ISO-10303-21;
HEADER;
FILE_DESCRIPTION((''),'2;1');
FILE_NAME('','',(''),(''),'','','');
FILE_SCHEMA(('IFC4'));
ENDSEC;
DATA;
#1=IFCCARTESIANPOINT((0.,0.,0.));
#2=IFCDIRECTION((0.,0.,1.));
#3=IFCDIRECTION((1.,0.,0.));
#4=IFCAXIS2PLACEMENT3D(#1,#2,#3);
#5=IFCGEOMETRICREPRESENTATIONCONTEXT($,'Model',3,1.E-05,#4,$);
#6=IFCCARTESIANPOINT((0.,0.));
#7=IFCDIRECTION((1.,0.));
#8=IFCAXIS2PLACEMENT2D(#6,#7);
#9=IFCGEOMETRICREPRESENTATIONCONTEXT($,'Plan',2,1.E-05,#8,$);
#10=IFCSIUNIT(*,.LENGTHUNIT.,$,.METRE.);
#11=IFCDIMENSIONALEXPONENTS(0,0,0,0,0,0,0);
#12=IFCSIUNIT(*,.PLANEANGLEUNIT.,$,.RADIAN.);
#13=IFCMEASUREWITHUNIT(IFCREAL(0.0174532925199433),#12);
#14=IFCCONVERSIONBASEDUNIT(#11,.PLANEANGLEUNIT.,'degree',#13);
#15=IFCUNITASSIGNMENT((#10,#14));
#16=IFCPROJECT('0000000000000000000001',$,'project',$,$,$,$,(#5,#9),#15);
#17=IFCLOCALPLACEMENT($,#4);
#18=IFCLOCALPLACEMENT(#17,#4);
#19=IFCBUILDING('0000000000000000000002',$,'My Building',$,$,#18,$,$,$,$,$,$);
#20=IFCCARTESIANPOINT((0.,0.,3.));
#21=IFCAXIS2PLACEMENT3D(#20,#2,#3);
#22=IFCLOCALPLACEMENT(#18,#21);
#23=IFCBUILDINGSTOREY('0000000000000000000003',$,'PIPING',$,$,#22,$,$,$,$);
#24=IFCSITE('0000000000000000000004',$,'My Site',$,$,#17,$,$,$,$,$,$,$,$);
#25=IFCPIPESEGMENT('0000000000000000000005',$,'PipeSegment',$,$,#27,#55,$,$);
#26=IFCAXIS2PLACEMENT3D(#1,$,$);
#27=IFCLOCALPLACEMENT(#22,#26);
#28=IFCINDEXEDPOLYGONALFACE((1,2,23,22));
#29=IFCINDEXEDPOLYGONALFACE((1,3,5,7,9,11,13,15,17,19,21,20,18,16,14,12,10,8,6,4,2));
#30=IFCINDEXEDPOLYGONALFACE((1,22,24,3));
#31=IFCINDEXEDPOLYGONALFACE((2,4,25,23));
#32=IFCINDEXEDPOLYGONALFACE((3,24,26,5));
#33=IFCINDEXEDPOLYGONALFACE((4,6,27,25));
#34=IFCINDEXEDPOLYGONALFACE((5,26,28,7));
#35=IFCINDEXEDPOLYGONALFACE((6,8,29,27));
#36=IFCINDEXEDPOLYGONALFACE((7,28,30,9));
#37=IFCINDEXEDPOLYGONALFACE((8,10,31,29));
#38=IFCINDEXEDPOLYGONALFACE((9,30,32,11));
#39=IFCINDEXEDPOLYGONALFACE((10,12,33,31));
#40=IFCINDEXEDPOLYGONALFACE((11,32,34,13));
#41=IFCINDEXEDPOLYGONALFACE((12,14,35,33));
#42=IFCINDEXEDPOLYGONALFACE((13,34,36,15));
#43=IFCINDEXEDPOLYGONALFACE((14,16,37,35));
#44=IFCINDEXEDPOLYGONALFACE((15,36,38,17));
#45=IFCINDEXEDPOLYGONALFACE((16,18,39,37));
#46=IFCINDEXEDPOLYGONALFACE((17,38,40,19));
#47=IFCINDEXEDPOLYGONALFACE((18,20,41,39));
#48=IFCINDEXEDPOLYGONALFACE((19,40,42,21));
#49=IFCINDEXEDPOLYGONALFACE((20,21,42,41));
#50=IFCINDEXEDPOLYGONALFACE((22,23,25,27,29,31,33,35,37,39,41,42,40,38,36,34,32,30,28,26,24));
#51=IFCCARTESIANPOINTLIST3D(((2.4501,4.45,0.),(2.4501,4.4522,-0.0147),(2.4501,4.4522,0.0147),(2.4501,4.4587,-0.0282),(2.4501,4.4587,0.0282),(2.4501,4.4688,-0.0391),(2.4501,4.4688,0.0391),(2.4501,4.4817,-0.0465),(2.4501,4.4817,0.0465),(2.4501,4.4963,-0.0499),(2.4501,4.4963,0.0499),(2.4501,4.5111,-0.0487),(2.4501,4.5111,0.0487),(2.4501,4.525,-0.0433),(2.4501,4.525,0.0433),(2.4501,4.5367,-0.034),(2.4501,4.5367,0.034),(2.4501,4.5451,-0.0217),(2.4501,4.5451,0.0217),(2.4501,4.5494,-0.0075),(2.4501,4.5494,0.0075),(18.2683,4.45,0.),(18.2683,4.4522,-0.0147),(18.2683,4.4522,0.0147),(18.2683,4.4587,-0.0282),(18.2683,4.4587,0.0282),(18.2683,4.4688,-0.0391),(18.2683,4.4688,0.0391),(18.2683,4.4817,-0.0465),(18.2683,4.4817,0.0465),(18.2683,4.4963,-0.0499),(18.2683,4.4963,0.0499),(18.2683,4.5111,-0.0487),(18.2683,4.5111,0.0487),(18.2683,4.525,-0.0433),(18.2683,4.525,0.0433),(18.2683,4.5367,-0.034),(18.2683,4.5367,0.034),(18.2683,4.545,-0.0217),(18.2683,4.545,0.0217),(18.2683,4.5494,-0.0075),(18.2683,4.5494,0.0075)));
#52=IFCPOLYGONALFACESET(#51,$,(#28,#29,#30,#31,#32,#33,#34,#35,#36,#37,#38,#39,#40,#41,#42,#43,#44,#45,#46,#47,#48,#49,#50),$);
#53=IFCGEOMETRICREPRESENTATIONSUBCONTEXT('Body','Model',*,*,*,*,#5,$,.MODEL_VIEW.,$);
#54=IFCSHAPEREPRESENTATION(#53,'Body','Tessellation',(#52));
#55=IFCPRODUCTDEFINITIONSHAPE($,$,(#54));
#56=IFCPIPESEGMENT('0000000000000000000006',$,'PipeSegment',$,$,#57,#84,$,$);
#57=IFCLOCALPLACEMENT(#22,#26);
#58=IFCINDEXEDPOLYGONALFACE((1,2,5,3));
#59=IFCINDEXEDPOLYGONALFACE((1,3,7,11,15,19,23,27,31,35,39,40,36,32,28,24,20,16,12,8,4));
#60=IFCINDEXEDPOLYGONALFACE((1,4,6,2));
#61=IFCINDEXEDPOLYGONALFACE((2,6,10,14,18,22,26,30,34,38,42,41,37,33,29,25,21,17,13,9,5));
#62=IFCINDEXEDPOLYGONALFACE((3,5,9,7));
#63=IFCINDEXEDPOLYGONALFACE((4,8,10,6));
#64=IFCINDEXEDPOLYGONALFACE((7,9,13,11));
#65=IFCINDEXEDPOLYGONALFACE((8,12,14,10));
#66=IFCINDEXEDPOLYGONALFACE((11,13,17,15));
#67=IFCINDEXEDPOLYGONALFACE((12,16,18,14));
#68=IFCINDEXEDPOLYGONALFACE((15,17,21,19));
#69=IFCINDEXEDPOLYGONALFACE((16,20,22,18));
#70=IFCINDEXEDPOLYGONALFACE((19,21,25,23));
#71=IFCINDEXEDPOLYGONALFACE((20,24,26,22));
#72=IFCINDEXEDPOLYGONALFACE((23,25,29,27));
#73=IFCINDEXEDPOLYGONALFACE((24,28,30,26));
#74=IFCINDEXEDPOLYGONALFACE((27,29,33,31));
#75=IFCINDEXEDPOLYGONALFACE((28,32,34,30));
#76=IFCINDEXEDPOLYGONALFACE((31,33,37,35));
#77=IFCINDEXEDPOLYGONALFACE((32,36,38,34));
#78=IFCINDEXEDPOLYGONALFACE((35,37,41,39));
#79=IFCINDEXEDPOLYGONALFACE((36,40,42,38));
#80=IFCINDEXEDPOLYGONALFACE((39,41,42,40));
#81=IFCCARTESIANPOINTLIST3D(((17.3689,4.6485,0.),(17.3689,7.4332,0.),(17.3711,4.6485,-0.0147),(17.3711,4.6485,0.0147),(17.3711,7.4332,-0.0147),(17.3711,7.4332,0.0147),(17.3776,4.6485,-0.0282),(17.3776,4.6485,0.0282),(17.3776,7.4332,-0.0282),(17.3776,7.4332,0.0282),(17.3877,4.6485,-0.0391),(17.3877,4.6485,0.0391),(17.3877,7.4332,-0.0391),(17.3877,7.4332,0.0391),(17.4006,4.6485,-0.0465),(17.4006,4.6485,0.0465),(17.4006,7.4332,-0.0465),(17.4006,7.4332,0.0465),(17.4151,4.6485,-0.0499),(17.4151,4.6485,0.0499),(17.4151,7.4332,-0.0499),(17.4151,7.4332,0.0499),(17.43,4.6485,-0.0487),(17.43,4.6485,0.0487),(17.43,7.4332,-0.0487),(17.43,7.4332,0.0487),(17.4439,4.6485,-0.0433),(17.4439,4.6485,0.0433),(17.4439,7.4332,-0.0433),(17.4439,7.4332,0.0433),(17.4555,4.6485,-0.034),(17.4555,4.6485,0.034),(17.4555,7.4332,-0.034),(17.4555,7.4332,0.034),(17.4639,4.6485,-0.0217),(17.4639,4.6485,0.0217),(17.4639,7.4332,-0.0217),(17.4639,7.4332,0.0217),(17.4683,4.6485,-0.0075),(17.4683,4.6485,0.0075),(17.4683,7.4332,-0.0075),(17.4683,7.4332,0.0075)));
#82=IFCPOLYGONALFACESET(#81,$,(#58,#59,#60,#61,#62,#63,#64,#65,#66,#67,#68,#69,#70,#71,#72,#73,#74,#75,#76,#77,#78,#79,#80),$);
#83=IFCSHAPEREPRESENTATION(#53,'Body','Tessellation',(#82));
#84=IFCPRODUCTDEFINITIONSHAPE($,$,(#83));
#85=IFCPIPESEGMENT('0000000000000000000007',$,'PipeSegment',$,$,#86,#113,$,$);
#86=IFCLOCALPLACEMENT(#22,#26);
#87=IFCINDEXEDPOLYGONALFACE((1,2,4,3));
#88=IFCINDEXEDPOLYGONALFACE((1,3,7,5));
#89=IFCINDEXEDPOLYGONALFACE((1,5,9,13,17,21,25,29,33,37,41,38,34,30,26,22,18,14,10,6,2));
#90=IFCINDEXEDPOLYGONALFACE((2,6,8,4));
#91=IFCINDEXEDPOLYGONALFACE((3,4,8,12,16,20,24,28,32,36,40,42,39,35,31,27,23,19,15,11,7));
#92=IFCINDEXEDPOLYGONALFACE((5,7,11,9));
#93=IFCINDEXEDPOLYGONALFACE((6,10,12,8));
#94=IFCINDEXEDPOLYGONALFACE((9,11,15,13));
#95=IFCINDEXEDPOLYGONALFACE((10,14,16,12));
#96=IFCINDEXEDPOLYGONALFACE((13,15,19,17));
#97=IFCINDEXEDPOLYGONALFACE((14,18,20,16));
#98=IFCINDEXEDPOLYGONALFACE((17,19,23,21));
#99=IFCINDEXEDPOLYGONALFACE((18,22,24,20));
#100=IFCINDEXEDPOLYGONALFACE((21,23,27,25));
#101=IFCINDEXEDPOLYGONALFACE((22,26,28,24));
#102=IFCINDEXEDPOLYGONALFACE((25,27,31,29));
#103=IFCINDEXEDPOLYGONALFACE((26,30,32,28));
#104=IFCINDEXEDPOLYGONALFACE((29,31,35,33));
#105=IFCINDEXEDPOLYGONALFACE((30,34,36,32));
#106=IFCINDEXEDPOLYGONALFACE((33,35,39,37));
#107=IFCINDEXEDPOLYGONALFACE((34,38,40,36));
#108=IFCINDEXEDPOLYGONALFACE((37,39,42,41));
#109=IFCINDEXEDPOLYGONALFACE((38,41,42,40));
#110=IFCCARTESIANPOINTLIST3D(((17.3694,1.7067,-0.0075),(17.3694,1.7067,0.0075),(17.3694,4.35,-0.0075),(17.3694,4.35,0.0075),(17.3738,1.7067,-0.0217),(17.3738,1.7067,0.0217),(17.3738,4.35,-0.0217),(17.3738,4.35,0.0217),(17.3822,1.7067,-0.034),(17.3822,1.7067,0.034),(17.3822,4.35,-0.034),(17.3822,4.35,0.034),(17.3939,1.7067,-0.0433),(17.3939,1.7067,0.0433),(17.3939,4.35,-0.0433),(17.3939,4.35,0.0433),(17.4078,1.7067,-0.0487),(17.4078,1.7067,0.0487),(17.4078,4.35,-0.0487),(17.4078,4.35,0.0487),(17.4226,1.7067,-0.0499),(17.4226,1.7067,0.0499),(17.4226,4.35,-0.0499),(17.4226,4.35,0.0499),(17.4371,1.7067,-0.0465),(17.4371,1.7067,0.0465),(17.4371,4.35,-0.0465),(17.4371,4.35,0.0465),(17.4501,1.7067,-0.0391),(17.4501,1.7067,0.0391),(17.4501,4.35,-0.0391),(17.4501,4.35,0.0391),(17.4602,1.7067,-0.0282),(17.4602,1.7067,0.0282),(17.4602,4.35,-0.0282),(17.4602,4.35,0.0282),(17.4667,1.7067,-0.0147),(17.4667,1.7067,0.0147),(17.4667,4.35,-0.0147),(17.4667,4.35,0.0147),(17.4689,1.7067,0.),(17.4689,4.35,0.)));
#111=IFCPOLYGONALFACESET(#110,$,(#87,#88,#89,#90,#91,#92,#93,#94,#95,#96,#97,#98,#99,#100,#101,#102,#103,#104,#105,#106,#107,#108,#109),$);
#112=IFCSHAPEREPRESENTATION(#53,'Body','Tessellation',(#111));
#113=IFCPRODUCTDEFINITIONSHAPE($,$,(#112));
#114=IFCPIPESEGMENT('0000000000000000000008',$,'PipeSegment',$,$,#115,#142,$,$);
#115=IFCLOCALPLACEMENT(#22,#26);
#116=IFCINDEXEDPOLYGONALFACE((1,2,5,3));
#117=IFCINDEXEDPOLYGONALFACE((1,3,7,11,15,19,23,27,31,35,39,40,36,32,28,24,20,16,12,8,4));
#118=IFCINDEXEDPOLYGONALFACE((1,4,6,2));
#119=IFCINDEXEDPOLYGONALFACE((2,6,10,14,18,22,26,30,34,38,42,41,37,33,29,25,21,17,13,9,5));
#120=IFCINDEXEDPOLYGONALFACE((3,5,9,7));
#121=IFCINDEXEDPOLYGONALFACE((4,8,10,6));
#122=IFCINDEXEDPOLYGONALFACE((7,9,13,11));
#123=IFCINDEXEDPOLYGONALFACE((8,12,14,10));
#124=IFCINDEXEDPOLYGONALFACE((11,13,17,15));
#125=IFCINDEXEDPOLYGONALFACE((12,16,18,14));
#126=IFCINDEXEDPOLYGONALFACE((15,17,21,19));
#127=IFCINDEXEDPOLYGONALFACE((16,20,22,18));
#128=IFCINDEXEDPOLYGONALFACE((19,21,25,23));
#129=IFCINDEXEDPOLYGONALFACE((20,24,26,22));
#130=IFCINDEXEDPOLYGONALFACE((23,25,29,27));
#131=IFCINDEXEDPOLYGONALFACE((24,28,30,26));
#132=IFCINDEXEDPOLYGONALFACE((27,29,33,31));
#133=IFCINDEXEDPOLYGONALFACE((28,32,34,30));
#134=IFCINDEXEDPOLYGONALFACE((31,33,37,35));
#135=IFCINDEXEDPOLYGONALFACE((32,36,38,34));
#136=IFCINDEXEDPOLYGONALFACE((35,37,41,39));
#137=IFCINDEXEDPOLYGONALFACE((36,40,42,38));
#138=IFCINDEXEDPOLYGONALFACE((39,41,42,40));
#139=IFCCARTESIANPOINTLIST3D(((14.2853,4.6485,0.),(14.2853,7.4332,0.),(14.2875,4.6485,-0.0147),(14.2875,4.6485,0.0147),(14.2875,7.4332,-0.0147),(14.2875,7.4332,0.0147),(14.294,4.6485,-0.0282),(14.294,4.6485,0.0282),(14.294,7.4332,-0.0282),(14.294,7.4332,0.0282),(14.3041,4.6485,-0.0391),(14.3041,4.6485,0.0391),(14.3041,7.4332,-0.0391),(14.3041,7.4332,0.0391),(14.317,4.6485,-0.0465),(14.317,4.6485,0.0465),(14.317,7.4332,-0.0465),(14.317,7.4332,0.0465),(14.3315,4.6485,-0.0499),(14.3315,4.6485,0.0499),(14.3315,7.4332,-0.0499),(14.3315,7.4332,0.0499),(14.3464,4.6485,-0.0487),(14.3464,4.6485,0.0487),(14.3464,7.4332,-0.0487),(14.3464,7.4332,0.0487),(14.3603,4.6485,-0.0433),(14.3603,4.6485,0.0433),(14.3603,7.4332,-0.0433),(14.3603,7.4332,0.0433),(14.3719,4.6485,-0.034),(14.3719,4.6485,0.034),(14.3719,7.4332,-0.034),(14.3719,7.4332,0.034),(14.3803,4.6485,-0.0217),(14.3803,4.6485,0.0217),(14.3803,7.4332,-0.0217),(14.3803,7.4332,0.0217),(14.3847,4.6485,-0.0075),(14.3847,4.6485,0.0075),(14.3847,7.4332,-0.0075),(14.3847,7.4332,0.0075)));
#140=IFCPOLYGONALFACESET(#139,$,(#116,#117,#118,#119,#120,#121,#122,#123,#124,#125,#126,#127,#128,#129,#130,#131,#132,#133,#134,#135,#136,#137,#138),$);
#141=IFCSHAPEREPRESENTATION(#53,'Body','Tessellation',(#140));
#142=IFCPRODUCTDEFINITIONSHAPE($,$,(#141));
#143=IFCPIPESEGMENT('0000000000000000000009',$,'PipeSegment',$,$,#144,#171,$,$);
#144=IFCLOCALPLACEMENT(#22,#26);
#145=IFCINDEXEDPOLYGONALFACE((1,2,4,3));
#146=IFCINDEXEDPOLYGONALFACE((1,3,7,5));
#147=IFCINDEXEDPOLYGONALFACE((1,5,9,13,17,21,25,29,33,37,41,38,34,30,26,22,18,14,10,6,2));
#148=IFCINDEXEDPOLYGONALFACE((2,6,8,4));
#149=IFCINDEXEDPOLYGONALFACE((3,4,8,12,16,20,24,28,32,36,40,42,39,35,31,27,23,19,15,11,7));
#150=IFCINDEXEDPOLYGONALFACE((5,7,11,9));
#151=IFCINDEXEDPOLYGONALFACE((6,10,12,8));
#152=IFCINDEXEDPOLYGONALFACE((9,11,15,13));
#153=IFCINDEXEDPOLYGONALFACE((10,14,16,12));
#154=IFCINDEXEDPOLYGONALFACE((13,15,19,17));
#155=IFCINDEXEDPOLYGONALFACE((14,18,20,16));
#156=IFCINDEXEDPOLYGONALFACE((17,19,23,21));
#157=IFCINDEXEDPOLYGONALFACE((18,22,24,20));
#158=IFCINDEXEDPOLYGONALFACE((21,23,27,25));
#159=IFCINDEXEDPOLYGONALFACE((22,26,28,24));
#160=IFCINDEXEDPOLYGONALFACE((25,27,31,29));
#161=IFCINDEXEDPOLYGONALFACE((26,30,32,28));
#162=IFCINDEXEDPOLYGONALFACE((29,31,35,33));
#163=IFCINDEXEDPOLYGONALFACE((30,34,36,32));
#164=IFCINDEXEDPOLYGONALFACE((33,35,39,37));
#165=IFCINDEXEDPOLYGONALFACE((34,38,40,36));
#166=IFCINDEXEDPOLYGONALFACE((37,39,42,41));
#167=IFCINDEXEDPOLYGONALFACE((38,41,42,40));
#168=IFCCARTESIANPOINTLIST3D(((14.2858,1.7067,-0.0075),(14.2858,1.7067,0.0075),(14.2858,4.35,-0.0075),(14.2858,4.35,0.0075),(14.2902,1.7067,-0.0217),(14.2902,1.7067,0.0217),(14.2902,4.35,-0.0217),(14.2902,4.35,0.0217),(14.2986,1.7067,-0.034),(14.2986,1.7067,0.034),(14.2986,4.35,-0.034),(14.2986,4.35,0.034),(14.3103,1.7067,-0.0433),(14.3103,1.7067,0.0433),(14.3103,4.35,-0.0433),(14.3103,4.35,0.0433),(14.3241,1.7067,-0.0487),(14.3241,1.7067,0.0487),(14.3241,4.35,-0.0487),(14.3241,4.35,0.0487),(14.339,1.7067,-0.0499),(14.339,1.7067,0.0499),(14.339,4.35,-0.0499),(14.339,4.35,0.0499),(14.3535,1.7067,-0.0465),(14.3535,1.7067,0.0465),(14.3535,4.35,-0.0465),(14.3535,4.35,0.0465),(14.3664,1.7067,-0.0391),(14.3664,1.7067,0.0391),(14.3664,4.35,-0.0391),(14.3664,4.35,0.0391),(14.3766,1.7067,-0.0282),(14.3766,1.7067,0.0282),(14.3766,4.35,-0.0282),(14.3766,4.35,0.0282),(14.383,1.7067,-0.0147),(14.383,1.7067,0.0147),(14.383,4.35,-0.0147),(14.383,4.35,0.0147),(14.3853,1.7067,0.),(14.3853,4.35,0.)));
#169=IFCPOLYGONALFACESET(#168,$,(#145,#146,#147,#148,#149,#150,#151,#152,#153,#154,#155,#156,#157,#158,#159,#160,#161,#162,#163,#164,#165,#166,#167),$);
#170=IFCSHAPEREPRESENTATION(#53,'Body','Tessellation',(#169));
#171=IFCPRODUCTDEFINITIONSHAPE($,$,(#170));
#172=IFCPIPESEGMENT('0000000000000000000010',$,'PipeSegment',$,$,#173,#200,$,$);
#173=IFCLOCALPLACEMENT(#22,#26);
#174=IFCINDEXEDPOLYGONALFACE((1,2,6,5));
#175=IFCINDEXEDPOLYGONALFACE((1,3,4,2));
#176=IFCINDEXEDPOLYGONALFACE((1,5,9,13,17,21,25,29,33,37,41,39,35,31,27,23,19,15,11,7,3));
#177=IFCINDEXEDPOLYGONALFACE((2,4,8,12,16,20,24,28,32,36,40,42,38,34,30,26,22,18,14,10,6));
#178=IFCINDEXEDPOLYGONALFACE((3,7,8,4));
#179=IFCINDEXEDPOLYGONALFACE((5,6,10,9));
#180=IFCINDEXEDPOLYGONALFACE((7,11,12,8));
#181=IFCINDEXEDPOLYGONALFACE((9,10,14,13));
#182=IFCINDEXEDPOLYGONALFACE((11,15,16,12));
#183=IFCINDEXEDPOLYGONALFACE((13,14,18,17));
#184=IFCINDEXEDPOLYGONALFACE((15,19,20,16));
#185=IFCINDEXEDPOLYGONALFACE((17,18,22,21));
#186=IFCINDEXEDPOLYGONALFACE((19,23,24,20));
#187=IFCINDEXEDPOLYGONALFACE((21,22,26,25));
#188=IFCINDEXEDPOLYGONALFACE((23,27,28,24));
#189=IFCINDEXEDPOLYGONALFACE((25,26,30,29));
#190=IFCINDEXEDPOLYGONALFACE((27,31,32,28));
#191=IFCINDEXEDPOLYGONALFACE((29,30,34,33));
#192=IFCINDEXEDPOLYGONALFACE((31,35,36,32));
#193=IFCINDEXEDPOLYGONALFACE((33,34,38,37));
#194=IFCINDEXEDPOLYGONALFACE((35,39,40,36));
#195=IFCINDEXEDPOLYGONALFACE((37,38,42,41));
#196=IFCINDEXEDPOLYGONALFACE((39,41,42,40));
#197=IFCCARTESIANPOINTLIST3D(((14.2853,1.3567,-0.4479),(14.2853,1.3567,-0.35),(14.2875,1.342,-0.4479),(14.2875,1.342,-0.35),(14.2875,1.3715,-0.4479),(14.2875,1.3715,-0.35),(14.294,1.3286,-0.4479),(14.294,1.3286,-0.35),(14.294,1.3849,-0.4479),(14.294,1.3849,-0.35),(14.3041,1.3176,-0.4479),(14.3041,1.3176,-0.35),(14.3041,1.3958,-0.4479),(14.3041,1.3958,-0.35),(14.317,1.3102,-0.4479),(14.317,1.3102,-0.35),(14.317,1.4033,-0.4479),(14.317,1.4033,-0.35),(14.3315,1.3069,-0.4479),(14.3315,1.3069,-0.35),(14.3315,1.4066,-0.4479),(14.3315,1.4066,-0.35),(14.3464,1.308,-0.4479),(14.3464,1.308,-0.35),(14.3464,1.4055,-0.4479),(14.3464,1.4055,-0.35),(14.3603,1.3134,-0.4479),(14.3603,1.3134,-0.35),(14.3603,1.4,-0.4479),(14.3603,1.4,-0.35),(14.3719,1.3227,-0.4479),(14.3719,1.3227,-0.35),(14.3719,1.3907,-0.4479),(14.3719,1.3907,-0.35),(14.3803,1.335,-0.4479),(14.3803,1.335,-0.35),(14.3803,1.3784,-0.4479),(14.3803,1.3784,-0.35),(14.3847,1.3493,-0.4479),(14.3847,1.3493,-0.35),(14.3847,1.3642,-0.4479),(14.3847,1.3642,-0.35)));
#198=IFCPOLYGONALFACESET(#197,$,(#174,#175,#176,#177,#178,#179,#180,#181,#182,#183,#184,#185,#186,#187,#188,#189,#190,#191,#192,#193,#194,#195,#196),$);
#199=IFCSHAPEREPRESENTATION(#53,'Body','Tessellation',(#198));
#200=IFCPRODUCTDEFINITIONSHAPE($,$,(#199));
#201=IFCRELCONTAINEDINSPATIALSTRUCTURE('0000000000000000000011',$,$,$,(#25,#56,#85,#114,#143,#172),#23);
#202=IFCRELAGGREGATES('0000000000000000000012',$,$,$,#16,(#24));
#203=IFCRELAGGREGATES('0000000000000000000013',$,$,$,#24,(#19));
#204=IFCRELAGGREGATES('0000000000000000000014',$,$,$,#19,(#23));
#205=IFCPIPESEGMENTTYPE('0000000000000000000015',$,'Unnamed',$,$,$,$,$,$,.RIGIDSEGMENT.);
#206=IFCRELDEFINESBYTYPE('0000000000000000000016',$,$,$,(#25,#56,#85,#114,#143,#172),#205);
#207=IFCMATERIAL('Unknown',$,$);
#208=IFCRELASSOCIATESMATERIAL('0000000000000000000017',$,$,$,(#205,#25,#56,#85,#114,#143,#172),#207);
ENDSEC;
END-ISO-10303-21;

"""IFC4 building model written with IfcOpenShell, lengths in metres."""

from ifc_helpers import new_model, entity, si_unit, converted_unit, frame, origin_with_axes, origin_2d_with_axis, place, context, subcontext, project, spatial, circle, extrude, material, material_profile, profile_set, profile_usage, type_object, element, save


model = new_model("IFC4")

# Units and contexts
model_context = context("Model", 3, precision=1e-05, world=origin_with_axes())
plan_context = context("Plan", 2, precision=1e-05, world=origin_2d_with_axis())
body_context = subcontext(model_context, "Body", "Model", "MODEL_VIEW")
ifc_project = project(units=[si_unit("LENGTHUNIT", "METRE"), converted_unit("PLANEANGLEUNIT", "degree", entity("IfcReal", 0.0174532925199433), si_unit("PLANEANGLEUNIT", "RADIAN"), dimensions=[0, 0, 0, 0, 0, 0, 0])], contexts=[model_context, plan_context])

# Site, building, storey
site_placement = place(None, origin_with_axes())
site = spatial("IfcSite", under=ifc_project, at=site_placement, Name="My Site")
building_placement = place(site_placement, origin_with_axes())
building = spatial("IfcBuilding", under=site, at=building_placement, Name="My Building")
storey_placement = place(building_placement, frame((0.0, 0.0, 3.0), z_axis=(0.0, 0.0, 1.0), x_axis=(1.0, 0.0, 0.0)))
storey = spatial("IfcBuildingStorey", under=building, at=storey_placement, Name="PIPING")

# Pipe segments
ifc_material = material(Name="Unknown")
ifc_material_profile_1 = material_profile(ifc_material, circle(Radius=0.05))
ifc_profile_set_1 = profile_set([ifc_material_profile_1])
ifc_profile_usage_1 = profile_usage(ifc_profile_set_1, cardinal=5)
pipe_segment_type = type_object("IfcPipeSegmentType", Name="Unnamed", PredefinedType="RIGIDSEGMENT", material=ifc_profile_set_1)
pipe_segment_1_placement = place(storey_placement, frame((18.2683, 4.5, 0.0), z_axis=(-1.0, 0.0, 0.0), x_axis=(0.0, -1.0, 0.0)))
element("IfcPipeSegment", 1, at=pipe_segment_1_placement, inside=storey, type_object=pipe_segment_type, material=ifc_profile_usage_1, Name="PipeSegment", context=body_context, shape_type="SweptSolid", body=[
    extrude(circle(Radius=0.05), origin_with_axes(), (0.0, 0.0, 1.0), 15.8182),
])
ifc_profile_usage_2 = profile_usage(ifc_profile_set_1, cardinal=5)
pipe_segment_2_placement = place(storey_placement, frame((17.4189, 4.6485, 0.0), z_axis=(0.0, 1.0, 0.0), x_axis=(-1.0, 0.0, 0.0)))
element("IfcPipeSegment", 2, at=pipe_segment_2_placement, inside=storey, type_object=pipe_segment_type, material=ifc_profile_usage_2, Name="PipeSegment", context=body_context, shape_type="SweptSolid", body=[
    extrude(circle(Radius=0.05), origin_with_axes(), (0.0, 0.0, 1.0), 2.7847),
])
ifc_profile_usage_3 = profile_usage(ifc_profile_set_1, cardinal=5)
pipe_segment_3_placement = place(storey_placement, frame((17.4189, 4.35, 0.0), z_axis=(0.0, -1.0, 0.0), x_axis=(1.0, 0.0, 0.0)))
element("IfcPipeSegment", 3, at=pipe_segment_3_placement, inside=storey, type_object=pipe_segment_type, material=ifc_profile_usage_3, Name="PipeSegment", context=body_context, shape_type="SweptSolid", body=[
    extrude(circle(Radius=0.05), origin_with_axes(), (0.0, 0.0, 1.0), 2.6433),
])
ifc_profile_usage_4 = profile_usage(ifc_profile_set_1, cardinal=5)
pipe_segment_4_placement = place(storey_placement, frame((14.3353, 4.6485, 0.0), z_axis=(0.0, 1.0, 0.0), x_axis=(-1.0, 0.0, 0.0)))
element("IfcPipeSegment", 4, at=pipe_segment_4_placement, inside=storey, type_object=pipe_segment_type, material=ifc_profile_usage_4, Name="PipeSegment", context=body_context, shape_type="SweptSolid", body=[
    extrude(circle(Radius=0.05), origin_with_axes(), (0.0, 0.0, 1.0), 2.7847),
])
ifc_profile_usage_5 = profile_usage(ifc_profile_set_1, cardinal=5)
pipe_segment_5_placement = place(storey_placement, frame((14.3353, 4.35, 0.0), z_axis=(0.0, -1.0, 0.0), x_axis=(1.0, 0.0, 0.0)))
element("IfcPipeSegment", 5, at=pipe_segment_5_placement, inside=storey, type_object=pipe_segment_type, material=ifc_profile_usage_5, Name="PipeSegment", context=body_context, shape_type="SweptSolid", body=[
    extrude(circle(Radius=0.05), origin_with_axes(), (0.0, 0.0, 1.0), 2.6433),
])
ifc_profile_usage_6 = profile_usage(ifc_profile_set_1, cardinal=5)
pipe_segment_6_placement = place(storey_placement, frame((14.3353, 1.3567, -0.35), z_axis=(0.0, 0.0, -1.0), x_axis=(-1.0, 0.0, 0.0)))
element("IfcPipeSegment", 6, at=pipe_segment_6_placement, inside=storey, type_object=pipe_segment_type, material=ifc_profile_usage_6, Name="PipeSegment", context=body_context, shape_type="SweptSolid", body=[
    extrude(circle(Radius=0.05), origin_with_axes(), (0.0, 0.0, 1.0), 0.0979),
])

save(model, "model.ifc")
